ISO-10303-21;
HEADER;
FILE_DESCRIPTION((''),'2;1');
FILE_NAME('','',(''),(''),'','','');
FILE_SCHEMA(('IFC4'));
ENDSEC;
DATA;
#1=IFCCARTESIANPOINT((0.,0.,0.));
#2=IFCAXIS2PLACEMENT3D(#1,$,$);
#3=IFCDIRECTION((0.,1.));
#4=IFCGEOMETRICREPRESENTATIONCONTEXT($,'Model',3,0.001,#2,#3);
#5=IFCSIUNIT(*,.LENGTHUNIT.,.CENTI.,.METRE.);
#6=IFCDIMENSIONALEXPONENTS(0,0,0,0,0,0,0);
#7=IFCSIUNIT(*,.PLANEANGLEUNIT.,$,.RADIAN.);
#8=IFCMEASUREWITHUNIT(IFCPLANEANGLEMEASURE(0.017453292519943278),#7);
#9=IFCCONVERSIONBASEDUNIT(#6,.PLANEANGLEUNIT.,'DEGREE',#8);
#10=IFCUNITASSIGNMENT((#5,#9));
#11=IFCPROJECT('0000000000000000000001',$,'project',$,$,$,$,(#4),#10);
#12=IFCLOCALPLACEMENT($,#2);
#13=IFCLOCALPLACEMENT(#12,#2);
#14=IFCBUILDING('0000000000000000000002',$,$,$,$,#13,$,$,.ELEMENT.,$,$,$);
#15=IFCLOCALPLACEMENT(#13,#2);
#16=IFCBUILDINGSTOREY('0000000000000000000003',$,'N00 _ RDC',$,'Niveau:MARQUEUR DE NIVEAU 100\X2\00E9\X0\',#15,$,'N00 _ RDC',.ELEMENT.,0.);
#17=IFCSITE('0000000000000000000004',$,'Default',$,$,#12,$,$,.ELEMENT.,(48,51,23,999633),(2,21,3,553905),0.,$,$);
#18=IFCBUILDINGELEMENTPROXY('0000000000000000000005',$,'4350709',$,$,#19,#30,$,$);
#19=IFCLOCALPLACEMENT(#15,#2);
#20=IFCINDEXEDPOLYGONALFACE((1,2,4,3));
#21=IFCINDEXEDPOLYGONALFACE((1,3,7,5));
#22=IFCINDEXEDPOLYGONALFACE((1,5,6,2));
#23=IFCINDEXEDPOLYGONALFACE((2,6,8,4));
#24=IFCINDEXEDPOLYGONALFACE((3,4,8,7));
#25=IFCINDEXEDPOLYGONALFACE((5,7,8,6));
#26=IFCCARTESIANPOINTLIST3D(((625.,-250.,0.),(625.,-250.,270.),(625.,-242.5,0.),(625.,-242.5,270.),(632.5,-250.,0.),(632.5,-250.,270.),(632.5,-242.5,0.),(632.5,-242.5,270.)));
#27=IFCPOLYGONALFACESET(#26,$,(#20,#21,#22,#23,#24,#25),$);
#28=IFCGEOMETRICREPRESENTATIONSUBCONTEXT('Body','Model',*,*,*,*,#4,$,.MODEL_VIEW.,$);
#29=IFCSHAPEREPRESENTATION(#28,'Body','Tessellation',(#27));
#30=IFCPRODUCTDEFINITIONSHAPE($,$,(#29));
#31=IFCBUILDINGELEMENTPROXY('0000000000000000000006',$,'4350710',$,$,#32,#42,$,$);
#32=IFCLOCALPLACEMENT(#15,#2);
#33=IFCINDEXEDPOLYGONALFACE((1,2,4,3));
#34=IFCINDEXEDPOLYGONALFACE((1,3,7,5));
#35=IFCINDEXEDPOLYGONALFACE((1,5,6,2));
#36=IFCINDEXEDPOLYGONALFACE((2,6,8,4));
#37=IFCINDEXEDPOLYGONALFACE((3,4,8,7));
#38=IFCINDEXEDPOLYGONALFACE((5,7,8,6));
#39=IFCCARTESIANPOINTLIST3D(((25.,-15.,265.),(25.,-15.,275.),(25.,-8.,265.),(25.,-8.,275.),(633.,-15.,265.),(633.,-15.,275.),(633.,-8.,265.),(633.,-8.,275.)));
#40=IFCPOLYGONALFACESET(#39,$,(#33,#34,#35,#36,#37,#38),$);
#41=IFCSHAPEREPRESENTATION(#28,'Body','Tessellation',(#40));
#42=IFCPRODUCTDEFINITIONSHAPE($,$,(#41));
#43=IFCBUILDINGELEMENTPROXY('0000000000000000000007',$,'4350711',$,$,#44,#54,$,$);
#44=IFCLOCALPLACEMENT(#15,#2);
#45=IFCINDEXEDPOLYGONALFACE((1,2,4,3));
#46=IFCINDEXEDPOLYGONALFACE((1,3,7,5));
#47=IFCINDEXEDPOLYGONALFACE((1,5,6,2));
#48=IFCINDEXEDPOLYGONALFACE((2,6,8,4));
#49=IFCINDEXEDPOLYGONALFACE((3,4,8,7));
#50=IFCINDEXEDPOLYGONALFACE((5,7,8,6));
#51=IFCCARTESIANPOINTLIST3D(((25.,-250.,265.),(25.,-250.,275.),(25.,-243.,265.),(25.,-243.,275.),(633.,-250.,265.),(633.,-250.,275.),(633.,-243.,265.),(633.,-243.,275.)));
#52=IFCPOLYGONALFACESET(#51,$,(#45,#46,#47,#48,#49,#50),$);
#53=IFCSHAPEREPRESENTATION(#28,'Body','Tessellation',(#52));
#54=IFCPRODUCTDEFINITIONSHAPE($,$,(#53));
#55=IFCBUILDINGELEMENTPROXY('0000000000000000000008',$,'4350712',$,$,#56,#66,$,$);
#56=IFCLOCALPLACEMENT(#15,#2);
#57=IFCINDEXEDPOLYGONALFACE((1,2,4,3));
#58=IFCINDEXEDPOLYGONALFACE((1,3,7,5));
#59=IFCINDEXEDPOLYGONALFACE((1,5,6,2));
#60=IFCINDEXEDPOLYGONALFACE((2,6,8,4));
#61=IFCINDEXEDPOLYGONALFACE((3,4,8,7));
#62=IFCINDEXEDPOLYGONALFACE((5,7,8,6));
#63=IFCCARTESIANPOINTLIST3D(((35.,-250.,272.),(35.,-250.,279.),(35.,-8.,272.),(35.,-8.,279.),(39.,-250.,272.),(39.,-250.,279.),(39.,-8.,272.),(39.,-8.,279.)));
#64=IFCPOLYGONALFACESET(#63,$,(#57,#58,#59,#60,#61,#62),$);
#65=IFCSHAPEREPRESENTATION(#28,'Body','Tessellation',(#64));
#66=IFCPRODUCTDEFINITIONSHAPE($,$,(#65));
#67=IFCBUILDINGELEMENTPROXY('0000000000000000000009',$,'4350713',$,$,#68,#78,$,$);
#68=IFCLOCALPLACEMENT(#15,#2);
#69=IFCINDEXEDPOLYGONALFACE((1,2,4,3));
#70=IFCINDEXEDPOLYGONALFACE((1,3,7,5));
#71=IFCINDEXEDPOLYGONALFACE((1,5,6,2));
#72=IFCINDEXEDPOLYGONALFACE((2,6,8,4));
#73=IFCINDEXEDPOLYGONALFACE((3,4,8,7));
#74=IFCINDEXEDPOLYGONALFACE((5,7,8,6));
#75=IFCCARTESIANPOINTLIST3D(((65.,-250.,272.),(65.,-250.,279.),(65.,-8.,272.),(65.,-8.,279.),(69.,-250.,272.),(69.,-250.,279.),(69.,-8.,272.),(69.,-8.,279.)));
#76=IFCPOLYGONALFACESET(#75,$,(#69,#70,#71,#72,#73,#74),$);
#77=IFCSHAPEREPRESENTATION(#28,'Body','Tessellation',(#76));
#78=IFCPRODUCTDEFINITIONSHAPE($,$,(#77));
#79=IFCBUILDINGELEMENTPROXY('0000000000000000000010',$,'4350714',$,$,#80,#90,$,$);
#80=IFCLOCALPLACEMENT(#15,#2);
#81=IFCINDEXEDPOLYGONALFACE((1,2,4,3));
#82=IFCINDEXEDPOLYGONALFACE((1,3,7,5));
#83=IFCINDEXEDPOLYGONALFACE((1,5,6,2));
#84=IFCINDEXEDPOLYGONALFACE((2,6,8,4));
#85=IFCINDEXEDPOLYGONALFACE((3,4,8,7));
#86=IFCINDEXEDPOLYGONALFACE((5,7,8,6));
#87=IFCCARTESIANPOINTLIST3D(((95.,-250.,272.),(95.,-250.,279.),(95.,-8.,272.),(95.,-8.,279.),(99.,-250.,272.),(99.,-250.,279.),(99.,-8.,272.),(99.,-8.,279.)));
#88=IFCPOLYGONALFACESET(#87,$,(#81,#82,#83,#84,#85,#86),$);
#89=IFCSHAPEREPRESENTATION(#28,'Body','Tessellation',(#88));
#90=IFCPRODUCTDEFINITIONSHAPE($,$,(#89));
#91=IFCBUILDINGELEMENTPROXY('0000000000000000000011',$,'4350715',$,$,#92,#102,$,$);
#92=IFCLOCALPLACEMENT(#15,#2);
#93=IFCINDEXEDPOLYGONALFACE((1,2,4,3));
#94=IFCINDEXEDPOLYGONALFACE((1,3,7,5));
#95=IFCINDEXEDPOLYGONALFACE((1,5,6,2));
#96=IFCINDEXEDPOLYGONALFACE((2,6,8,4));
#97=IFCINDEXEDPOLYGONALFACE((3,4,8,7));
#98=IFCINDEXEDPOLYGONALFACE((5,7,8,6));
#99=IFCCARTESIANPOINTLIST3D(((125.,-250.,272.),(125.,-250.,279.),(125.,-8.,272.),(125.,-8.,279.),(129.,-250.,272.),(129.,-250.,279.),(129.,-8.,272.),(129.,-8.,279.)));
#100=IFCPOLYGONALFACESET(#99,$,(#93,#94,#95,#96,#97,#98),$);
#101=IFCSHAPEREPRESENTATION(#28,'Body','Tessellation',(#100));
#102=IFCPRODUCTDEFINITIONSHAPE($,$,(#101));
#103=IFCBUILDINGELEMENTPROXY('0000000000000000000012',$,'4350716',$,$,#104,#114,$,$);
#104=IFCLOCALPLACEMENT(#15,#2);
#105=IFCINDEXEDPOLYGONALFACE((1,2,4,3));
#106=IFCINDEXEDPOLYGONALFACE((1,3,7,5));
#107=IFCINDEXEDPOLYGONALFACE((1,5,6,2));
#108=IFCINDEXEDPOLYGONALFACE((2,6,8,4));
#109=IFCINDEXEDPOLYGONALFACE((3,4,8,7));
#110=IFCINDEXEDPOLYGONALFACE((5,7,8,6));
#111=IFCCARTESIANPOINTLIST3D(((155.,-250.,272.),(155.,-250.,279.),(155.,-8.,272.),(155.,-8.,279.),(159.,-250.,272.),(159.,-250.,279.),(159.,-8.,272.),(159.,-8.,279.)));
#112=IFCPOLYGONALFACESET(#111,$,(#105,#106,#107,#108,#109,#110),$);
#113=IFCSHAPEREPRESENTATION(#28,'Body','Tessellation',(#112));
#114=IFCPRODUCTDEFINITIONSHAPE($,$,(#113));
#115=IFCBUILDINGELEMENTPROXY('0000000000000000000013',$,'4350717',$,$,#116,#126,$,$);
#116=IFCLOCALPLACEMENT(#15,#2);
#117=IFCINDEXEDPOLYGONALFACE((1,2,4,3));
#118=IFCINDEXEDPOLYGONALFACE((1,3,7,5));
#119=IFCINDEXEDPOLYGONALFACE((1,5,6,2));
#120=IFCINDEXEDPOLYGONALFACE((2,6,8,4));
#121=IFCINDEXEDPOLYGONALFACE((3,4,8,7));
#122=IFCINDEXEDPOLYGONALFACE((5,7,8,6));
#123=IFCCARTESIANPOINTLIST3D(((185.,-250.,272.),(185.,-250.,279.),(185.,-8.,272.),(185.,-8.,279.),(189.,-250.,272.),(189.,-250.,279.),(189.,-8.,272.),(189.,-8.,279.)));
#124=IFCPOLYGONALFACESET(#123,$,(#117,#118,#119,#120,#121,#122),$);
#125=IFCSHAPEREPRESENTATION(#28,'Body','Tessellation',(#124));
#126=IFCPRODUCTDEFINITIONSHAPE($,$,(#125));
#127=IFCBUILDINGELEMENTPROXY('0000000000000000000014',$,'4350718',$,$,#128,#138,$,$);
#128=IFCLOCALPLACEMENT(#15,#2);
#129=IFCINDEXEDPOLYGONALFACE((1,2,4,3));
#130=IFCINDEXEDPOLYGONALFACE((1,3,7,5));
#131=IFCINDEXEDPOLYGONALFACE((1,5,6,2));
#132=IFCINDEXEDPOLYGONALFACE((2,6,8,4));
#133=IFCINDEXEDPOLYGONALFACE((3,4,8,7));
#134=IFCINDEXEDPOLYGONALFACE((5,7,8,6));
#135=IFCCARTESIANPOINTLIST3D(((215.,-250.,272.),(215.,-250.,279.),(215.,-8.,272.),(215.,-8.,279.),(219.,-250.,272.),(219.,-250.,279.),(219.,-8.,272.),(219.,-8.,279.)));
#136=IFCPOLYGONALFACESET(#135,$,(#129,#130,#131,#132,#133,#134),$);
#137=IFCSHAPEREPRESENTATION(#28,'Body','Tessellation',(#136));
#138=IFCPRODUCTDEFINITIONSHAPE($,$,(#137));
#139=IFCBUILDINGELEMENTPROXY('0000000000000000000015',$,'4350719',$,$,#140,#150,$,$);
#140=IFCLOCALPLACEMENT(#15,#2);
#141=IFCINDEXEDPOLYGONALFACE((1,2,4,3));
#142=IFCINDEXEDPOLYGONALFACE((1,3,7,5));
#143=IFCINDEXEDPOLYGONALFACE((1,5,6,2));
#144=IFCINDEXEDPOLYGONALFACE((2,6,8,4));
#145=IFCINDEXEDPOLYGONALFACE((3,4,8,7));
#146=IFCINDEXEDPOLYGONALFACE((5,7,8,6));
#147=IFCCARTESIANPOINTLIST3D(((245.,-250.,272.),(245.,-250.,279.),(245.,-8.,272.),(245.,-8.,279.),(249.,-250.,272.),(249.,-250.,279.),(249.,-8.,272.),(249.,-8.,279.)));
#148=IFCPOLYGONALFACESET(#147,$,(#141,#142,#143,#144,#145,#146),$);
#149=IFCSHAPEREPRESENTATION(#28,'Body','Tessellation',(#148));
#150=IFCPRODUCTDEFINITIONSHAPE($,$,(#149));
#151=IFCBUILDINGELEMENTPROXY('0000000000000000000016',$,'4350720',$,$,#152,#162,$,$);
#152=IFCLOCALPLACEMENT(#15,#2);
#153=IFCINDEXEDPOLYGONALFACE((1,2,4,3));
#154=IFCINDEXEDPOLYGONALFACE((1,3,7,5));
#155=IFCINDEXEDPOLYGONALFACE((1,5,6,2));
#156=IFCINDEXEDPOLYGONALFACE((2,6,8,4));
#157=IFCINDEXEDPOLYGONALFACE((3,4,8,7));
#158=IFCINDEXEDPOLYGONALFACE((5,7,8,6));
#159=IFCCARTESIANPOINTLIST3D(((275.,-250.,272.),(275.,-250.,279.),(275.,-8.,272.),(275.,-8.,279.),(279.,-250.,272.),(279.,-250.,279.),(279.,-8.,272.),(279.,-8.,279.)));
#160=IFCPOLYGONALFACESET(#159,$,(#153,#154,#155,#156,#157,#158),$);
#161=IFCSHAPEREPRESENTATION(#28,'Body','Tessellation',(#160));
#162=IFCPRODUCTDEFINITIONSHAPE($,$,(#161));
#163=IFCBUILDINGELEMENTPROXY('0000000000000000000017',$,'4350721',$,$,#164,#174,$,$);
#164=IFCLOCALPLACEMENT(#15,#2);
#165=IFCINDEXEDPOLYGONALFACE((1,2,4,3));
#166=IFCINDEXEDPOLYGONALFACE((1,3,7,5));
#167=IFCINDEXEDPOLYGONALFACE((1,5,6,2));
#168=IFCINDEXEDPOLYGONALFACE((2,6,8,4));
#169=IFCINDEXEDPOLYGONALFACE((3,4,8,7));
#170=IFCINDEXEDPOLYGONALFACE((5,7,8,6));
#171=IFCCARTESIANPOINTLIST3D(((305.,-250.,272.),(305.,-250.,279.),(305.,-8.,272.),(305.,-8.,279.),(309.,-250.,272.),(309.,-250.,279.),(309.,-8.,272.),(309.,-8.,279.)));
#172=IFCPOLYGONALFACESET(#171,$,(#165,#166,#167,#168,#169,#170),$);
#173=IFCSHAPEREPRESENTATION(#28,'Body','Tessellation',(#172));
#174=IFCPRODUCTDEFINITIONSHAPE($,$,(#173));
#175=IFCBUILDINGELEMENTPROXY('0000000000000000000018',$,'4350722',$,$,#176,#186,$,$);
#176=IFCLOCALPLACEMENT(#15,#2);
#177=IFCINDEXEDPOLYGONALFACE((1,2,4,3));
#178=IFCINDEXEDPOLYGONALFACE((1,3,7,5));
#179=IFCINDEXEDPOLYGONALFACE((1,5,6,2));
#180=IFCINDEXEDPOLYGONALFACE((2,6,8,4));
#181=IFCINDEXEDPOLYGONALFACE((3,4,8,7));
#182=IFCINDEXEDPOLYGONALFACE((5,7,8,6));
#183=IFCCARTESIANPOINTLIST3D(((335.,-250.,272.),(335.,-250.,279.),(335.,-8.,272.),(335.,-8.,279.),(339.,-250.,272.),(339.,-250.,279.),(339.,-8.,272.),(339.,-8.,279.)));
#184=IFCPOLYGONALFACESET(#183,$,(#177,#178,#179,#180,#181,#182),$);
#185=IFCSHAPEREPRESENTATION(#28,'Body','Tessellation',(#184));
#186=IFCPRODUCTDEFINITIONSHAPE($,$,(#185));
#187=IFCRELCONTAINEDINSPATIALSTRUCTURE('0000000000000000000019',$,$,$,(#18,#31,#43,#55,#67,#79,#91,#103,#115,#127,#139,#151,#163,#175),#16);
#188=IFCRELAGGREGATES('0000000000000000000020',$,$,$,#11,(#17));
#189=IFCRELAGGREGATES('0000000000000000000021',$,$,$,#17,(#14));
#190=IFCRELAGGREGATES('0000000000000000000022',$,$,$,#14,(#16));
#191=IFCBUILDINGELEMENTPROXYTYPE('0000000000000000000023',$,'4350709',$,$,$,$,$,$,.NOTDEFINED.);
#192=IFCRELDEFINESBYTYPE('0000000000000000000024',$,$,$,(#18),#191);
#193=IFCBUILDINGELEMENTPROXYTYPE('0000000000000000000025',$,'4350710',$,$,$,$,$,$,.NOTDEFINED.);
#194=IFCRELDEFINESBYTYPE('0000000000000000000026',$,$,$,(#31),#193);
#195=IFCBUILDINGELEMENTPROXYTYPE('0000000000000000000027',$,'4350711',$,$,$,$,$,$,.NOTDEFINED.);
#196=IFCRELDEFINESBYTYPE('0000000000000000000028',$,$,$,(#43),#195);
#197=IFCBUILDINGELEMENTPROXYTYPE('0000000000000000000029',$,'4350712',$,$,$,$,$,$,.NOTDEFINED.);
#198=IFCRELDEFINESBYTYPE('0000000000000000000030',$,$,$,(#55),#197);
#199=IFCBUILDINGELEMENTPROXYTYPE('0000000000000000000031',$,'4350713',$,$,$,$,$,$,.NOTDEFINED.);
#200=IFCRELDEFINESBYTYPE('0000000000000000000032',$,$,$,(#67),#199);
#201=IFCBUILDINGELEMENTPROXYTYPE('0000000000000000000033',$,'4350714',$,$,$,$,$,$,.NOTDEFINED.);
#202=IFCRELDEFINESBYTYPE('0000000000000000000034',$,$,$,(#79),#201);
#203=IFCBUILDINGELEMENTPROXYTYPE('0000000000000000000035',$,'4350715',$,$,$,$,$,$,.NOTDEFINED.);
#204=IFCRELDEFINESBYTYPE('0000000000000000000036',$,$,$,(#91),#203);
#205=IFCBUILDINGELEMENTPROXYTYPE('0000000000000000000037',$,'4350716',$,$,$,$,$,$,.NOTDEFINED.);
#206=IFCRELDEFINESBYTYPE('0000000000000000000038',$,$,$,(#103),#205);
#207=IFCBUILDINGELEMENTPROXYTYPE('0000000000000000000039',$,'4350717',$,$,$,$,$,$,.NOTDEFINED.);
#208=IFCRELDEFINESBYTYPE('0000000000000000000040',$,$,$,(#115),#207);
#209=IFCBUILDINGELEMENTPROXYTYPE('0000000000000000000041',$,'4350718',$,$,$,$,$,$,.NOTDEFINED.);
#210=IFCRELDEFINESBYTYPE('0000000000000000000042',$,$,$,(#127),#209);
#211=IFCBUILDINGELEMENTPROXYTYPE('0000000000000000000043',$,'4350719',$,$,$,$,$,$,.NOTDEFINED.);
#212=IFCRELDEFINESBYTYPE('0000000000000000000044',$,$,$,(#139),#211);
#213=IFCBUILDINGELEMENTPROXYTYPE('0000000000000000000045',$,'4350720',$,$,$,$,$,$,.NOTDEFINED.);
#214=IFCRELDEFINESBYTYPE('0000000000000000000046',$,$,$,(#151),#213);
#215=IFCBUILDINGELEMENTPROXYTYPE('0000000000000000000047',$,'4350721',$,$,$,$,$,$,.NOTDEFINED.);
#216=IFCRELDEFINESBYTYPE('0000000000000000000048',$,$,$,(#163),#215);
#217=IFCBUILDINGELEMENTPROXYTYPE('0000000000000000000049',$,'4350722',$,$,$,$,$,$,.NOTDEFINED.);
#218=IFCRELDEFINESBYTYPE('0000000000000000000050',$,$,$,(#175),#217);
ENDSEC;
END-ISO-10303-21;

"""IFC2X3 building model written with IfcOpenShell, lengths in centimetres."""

from ifc_helpers import new_model, entity, si_unit, converted_unit, direction, frame, frame_2d, origin, origin_2d_with_axis, place, context, subcontext, project, spatial, rectangle, extrude, type_object, element, save


model = new_model("IFC2X3")

# Units and contexts
model_context = context("Model", 3, precision=0.001, world=origin(), true_north=direction((0.0, 1.0)))
body_context = subcontext(model_context, "Body", "Model", "MODEL_VIEW")
ifc_project = project(units=[si_unit("LENGTHUNIT", "METRE", prefix="CENTI"), converted_unit("PLANEANGLEUNIT", "DEGREE", entity("IfcPlaneAngleMeasure", 0.017453292519943278), si_unit("PLANEANGLEUNIT", "RADIAN"), dimensions=[0, 0, 0, 0, 0, 0, 0])], contexts=[model_context])

# Site, building, storey
site_placement = place(None, origin())
site = spatial("IfcSite", under=ifc_project, at=site_placement, Name="Default", CompositionType="ELEMENT", RefLatitude=(48, 51, 23, 999633), RefLongitude=(2, 21, 3, 553905), RefElevation=0.0)
building_placement = place(site_placement, origin())
building = spatial("IfcBuilding", under=site, at=building_placement, CompositionType="ELEMENT")
storey_placement = place(building_placement, origin())
storey = spatial("IfcBuildingStorey", under=building, at=storey_placement, Name="N00 _ RDC", ObjectType="Niveau:MARQUEUR DE NIVEAU 100é", LongName="N00 _ RDC", CompositionType="ELEMENT", Elevation=0.0)

# Building element proxies
building_element_proxy_type_1 = type_object("IfcBuildingElementProxyType", Name="4350709", PredefinedType="NOTDEFINED")
proxy_1_placement = place(storey_placement, origin())
element("IfcBuildingElementProxy", 1, at=proxy_1_placement, inside=storey, type_object=building_element_proxy_type_1, Name="4350709", context=body_context, shape_type="SweptSolid", body=[
    extrude(rectangle(XDim=7.5, YDim=7.5, at=origin_2d_with_axis()), frame((628.75, -246.25, 0.0)), (0.0, 0.0, 1.0), 270.0),
])
building_element_proxy_type_2 = type_object("IfcBuildingElementProxyType", Name="4350710", PredefinedType="NOTDEFINED")
proxy_2_placement = place(storey_placement, origin())
element("IfcBuildingElementProxy", 2, at=proxy_2_placement, inside=storey, type_object=building_element_proxy_type_2, Name="4350710", context=body_context, shape_type="SweptSolid", body=[
    extrude(rectangle(XDim=608.0, YDim=7.0, at=frame_2d((0.0, 0.0), x_axis=(1.0, 0.0))), frame((329.0, -11.5, 265.0)), (0.0, 0.0, 1.0), 10.0),
])
building_element_proxy_type_3 = type_object("IfcBuildingElementProxyType", Name="4350711", PredefinedType="NOTDEFINED")
proxy_3_placement = place(storey_placement, origin())
element("IfcBuildingElementProxy", 3, at=proxy_3_placement, inside=storey, type_object=building_element_proxy_type_3, Name="4350711", context=body_context, shape_type="SweptSolid", body=[
    extrude(rectangle(XDim=608.0, YDim=7.0, at=frame_2d((0.0, 0.0), x_axis=(1.0, 0.0))), frame((329.0, -246.5, 265.0)), (0.0, 0.0, 1.0), 10.0),
])
building_element_proxy_type_4 = type_object("IfcBuildingElementProxyType", Name="4350712", PredefinedType="NOTDEFINED")
proxy_4_placement = place(storey_placement, origin())
element("IfcBuildingElementProxy", 4, at=proxy_4_placement, inside=storey, type_object=building_element_proxy_type_4, Name="4350712", context=body_context, shape_type="SweptSolid", body=[
    extrude(rectangle(XDim=4.0, YDim=242.0, at=frame_2d((0.0, 0.0), x_axis=(1.0, 0.0))), frame((37.0, -129.0, 272.0)), (0.0, 0.0, 1.0), 7.0),
])
building_element_proxy_type_5 = type_object("IfcBuildingElementProxyType", Name="4350713", PredefinedType="NOTDEFINED")
proxy_5_placement = place(storey_placement, origin())
element("IfcBuildingElementProxy", 5, at=proxy_5_placement, inside=storey, type_object=building_element_proxy_type_5, Name="4350713", context=body_context, shape_type="SweptSolid", body=[
    extrude(rectangle(XDim=4.0, YDim=242.0, at=frame_2d((0.0, 0.0), x_axis=(1.0, 0.0))), frame((67.0, -129.0, 272.0)), (0.0, 0.0, 1.0), 7.0),
])
building_element_proxy_type_6 = type_object("IfcBuildingElementProxyType", Name="4350714", PredefinedType="NOTDEFINED")
proxy_6_placement = place(storey_placement, origin())
element("IfcBuildingElementProxy", 6, at=proxy_6_placement, inside=storey, type_object=building_element_proxy_type_6, Name="4350714", context=body_context, shape_type="SweptSolid", body=[
    extrude(rectangle(XDim=4.0, YDim=242.0, at=frame_2d((0.0, 0.0), x_axis=(1.0, 0.0))), frame((97.0, -129.0, 272.0)), (0.0, 0.0, 1.0), 7.0),
])
building_element_proxy_type_7 = type_object("IfcBuildingElementProxyType", Name="4350715", PredefinedType="NOTDEFINED")
proxy_7_placement = place(storey_placement, origin())
element("IfcBuildingElementProxy", 7, at=proxy_7_placement, inside=storey, type_object=building_element_proxy_type_7, Name="4350715", context=body_context, shape_type="SweptSolid", body=[
    extrude(rectangle(XDim=4.0, YDim=242.0, at=frame_2d((0.0, 0.0), x_axis=(1.0, 0.0))), frame((127.0, -129.0, 272.0)), (0.0, 0.0, 1.0), 7.0),
])
building_element_proxy_type_8 = type_object("IfcBuildingElementProxyType", Name="4350716", PredefinedType="NOTDEFINED")
proxy_8_placement = place(storey_placement, origin())
element("IfcBuildingElementProxy", 8, at=proxy_8_placement, inside=storey, type_object=building_element_proxy_type_8, Name="4350716", context=body_context, shape_type="SweptSolid", body=[
    extrude(rectangle(XDim=4.0, YDim=242.0, at=frame_2d((0.0, 0.0), x_axis=(1.0, 0.0))), frame((157.0, -129.0, 272.0)), (0.0, 0.0, 1.0), 7.0),
])
building_element_proxy_type_9 = type_object("IfcBuildingElementProxyType", Name="4350717", PredefinedType="NOTDEFINED")
proxy_9_placement = place(storey_placement, origin())
element("IfcBuildingElementProxy", 9, at=proxy_9_placement, inside=storey, type_object=building_element_proxy_type_9, Name="4350717", context=body_context, shape_type="SweptSolid", body=[
    extrude(rectangle(XDim=4.0, YDim=242.0, at=frame_2d((0.0, 0.0), x_axis=(1.0, 0.0))), frame((187.0, -129.0, 272.0)), (0.0, 0.0, 1.0), 7.0),
])
building_element_proxy_type_10 = type_object("IfcBuildingElementProxyType", Name="4350718", PredefinedType="NOTDEFINED")
proxy_10_placement = place(storey_placement, origin())
element("IfcBuildingElementProxy", 10, at=proxy_10_placement, inside=storey, type_object=building_element_proxy_type_10, Name="4350718", context=body_context, shape_type="SweptSolid", body=[
    extrude(rectangle(XDim=4.0, YDim=242.0, at=frame_2d((0.0, 0.0), x_axis=(1.0, 0.0))), frame((217.0, -129.0, 272.0)), (0.0, 0.0, 1.0), 7.0),
])
building_element_proxy_type_11 = type_object("IfcBuildingElementProxyType", Name="4350719", PredefinedType="NOTDEFINED")
proxy_11_placement = place(storey_placement, origin())
element("IfcBuildingElementProxy", 11, at=proxy_11_placement, inside=storey, type_object=building_element_proxy_type_11, Name="4350719", context=body_context, shape_type="SweptSolid", body=[
    extrude(rectangle(XDim=4.0, YDim=242.0, at=frame_2d((0.0, 0.0), x_axis=(1.0, 0.0))), frame((247.0, -129.0, 272.0)), (0.0, 0.0, 1.0), 7.0),
])
building_element_proxy_type_12 = type_object("IfcBuildingElementProxyType", Name="4350720", PredefinedType="NOTDEFINED")
proxy_12_placement = place(storey_placement, origin())
element("IfcBuildingElementProxy", 12, at=proxy_12_placement, inside=storey, type_object=building_element_proxy_type_12, Name="4350720", context=body_context, shape_type="SweptSolid", body=[
    extrude(rectangle(XDim=4.0, YDim=242.0, at=frame_2d((0.0, 0.0), x_axis=(1.0, 0.0))), frame((277.0, -129.0, 272.0)), (0.0, 0.0, 1.0), 7.0),
])
building_element_proxy_type_13 = type_object("IfcBuildingElementProxyType", Name="4350721", PredefinedType="NOTDEFINED")
proxy_13_placement = place(storey_placement, origin())
element("IfcBuildingElementProxy", 13, at=proxy_13_placement, inside=storey, type_object=building_element_proxy_type_13, Name="4350721", context=body_context, shape_type="SweptSolid", body=[
    extrude(rectangle(XDim=4.0, YDim=242.0, at=frame_2d((0.0, 0.0), x_axis=(1.0, 0.0))), frame((307.0, -129.0, 272.0)), (0.0, 0.0, 1.0), 7.0),
])
building_element_proxy_type_14 = type_object("IfcBuildingElementProxyType", Name="4350722", PredefinedType="NOTDEFINED")
proxy_14_placement = place(storey_placement, origin())
element("IfcBuildingElementProxy", 14, at=proxy_14_placement, inside=storey, type_object=building_element_proxy_type_14, Name="4350722", context=body_context, shape_type="SweptSolid", body=[
    extrude(rectangle(XDim=4.0, YDim=242.0, at=frame_2d((0.0, 0.0), x_axis=(1.0, 0.0))), frame((337.0, -129.0, 272.0)), (0.0, 0.0, 1.0), 7.0),
])

save(model, "model.ifc")
